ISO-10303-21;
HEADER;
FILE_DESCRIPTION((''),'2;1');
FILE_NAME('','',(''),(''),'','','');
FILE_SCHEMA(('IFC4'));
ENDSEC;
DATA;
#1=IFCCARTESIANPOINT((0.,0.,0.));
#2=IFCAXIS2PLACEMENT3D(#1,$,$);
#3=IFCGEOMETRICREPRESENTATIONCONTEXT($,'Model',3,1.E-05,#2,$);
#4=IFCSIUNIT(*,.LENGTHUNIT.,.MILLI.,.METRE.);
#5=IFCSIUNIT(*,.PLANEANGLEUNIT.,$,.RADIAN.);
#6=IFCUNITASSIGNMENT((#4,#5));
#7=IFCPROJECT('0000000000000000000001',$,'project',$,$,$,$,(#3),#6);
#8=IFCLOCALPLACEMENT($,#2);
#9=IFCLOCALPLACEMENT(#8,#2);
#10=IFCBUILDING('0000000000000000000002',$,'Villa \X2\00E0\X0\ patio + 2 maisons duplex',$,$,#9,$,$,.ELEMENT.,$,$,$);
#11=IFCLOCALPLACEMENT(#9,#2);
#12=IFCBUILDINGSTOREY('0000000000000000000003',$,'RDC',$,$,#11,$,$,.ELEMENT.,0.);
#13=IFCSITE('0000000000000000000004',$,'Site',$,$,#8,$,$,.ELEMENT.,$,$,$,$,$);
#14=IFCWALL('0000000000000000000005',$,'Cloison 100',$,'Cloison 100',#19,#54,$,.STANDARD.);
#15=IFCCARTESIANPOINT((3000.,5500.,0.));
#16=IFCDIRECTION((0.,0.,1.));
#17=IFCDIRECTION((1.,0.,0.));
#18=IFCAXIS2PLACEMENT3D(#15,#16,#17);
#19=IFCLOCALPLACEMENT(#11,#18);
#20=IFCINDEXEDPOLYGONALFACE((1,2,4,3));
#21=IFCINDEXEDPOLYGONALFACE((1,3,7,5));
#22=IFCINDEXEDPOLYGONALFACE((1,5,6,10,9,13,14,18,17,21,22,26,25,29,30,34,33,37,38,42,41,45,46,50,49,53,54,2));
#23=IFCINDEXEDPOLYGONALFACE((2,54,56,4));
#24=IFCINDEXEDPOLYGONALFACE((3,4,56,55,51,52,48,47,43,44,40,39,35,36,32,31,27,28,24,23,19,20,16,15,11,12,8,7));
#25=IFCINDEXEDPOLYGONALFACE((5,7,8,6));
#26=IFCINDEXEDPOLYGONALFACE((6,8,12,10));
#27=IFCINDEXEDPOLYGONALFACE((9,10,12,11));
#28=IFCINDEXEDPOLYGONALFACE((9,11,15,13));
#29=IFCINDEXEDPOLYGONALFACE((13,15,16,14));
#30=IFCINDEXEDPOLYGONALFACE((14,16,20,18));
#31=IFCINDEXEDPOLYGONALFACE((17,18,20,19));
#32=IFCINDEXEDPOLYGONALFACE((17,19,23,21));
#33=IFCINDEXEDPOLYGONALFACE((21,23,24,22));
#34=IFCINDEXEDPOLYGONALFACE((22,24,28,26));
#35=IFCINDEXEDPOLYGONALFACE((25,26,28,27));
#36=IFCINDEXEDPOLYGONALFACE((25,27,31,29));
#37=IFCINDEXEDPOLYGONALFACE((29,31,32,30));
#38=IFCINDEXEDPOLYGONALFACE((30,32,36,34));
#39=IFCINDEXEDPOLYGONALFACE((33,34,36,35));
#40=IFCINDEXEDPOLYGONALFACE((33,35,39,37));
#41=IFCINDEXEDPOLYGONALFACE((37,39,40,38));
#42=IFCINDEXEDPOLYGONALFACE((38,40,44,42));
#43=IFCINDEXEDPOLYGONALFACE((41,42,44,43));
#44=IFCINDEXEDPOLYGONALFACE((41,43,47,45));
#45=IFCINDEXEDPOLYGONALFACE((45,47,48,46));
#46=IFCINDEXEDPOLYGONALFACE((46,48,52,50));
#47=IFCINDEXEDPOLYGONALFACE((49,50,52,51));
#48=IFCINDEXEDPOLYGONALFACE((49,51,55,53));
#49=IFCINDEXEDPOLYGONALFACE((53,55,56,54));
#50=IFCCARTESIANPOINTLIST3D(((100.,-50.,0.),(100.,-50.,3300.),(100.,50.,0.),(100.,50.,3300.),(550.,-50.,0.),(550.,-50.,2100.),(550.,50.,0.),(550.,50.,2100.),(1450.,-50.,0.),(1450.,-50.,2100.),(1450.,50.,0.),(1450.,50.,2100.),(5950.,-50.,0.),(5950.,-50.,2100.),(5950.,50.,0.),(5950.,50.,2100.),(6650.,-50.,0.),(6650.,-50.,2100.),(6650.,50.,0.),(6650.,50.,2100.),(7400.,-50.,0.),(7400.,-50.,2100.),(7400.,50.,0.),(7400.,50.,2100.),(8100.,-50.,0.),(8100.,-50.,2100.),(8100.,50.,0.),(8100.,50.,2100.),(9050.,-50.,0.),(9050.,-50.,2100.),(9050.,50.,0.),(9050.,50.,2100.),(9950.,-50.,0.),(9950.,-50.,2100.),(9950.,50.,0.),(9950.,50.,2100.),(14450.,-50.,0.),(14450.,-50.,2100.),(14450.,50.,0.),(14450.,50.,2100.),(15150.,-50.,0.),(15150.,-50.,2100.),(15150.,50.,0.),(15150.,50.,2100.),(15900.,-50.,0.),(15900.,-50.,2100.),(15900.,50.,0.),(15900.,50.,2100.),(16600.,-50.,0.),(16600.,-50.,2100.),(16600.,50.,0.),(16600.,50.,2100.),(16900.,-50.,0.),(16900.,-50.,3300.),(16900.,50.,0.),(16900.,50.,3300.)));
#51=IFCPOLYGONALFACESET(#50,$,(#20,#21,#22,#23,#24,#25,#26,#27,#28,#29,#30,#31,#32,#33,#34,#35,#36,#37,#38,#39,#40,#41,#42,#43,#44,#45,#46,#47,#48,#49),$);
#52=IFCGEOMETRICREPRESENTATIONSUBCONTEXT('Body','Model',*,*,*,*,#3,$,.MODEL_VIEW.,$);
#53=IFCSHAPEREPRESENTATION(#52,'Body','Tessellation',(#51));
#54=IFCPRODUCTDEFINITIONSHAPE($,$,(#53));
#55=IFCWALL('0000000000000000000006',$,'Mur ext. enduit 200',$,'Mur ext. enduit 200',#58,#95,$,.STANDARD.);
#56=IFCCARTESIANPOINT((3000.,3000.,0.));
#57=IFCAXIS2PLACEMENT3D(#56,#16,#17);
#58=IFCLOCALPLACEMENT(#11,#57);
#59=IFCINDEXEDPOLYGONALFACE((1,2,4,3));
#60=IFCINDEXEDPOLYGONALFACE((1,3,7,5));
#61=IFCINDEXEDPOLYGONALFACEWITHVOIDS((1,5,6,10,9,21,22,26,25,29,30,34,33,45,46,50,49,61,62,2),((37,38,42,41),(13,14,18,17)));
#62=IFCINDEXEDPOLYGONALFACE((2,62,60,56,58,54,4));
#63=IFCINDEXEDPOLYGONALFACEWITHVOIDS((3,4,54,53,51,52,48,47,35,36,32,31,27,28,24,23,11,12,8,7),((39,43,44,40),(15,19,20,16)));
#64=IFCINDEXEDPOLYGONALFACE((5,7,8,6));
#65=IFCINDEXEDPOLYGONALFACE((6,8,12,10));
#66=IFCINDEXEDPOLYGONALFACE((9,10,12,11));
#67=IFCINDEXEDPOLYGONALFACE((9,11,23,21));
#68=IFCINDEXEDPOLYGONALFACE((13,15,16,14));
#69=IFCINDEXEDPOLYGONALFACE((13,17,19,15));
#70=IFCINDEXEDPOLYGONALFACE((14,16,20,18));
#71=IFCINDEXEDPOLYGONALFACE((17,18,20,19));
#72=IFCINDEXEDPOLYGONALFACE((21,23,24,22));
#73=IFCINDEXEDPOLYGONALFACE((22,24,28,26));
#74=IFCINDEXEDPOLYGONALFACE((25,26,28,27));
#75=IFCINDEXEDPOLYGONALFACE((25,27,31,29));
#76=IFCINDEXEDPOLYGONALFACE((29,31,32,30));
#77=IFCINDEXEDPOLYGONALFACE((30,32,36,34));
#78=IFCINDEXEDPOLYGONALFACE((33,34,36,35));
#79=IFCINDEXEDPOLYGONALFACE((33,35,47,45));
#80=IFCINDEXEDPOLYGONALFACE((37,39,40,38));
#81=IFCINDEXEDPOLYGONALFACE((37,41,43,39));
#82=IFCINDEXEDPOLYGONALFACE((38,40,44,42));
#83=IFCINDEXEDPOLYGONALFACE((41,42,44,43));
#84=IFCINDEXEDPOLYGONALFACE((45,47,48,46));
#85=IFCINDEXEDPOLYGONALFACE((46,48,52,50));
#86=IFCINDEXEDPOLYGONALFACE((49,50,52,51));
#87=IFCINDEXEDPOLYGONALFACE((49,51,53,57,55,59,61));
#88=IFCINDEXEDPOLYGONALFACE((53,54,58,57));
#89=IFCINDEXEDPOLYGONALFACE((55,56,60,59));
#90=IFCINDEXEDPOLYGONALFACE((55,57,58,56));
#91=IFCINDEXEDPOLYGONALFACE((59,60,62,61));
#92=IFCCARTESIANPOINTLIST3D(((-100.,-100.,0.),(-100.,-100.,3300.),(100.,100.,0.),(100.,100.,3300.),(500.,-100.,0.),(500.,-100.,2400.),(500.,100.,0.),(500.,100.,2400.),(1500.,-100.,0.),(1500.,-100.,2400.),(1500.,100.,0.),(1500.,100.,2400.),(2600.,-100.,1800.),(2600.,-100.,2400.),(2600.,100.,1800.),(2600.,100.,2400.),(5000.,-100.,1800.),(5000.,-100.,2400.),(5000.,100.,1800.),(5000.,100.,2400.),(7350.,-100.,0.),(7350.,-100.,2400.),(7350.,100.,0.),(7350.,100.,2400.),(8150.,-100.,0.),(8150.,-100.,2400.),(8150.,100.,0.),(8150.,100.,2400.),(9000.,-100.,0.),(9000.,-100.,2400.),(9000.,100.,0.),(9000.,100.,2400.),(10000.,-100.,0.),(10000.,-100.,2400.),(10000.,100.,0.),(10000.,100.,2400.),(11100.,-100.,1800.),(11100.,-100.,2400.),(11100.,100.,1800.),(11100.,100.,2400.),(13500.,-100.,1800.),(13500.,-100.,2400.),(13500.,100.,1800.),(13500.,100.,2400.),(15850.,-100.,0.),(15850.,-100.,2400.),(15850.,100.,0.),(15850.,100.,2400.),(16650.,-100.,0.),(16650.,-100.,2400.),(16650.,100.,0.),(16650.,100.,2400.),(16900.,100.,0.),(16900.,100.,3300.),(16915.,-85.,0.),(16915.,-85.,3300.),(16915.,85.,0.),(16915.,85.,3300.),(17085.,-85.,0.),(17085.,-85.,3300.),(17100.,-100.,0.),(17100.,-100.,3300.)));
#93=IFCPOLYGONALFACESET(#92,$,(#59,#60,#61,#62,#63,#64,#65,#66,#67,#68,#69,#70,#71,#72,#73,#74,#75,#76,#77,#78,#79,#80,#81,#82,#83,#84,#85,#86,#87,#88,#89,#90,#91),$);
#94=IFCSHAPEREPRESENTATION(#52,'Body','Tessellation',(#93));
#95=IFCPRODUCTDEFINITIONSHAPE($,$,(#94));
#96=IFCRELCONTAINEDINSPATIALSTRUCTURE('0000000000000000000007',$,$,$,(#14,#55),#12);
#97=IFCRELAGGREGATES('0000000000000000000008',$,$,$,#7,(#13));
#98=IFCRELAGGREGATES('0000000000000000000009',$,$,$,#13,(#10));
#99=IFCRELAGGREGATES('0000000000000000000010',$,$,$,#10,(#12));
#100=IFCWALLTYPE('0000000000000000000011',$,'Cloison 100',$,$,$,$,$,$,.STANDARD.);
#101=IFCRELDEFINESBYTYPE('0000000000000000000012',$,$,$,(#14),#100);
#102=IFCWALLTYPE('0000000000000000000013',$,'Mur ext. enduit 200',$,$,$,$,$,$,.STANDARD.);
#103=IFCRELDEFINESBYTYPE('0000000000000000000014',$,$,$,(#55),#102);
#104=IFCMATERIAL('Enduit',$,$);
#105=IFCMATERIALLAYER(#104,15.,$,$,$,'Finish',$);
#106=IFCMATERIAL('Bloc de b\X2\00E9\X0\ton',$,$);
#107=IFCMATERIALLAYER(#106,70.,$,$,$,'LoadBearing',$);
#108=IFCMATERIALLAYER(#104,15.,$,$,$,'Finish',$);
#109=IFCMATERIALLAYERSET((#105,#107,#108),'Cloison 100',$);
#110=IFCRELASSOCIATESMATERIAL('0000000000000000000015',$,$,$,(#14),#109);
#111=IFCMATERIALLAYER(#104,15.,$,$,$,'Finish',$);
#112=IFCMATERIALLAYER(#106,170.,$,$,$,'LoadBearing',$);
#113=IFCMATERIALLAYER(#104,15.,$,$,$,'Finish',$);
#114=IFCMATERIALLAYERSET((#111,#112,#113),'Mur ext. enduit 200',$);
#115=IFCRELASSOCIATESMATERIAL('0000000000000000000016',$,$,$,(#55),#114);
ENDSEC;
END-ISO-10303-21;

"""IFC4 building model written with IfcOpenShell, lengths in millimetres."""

from ifc_helpers import new_model, si_unit, frame, frame_2d, origin, place, context, subcontext, project, spatial, polyline, rectangle, outline, extrude, material, layer, layer_set, layer_usage, type_object, element, save


model = new_model("IFC4")

# Units and contexts
model_context = context("Model", 3, precision=1e-05, world=origin())
body_context = subcontext(model_context, "Body", "Model", "MODEL_VIEW")
ifc_project = project(units=[si_unit("LENGTHUNIT", "METRE", prefix="MILLI"), si_unit("PLANEANGLEUNIT", "RADIAN")], contexts=[model_context])

# Site, building, storey
site_placement = place(None, origin())
site = spatial("IfcSite", under=ifc_project, at=site_placement, Name="Site", CompositionType="ELEMENT")
building_placement = place(site_placement, origin())
building = spatial("IfcBuilding", under=site, at=building_placement, Name="Villa à patio + 2 maisons duplex", CompositionType="ELEMENT")
storey_placement = place(building_placement, origin())
storey = spatial("IfcBuildingStorey", under=building, at=storey_placement, Name="RDC", CompositionType="ELEMENT", Elevation=0.0)

# Shared definitions
ifc_material_1 = material(Name="Enduit")
ifc_layer_1 = layer(ifc_material_1, 15.0, Category="Finish")
ifc_material_2 = material(Name="Bloc de béton")
ifc_layer_2 = layer(ifc_material_2, 70.0, Category="LoadBearing")
ifc_layer_3 = layer(ifc_material_1, 15.0, Category="Finish")
ifc_layer_set_1 = layer_set([ifc_layer_1, ifc_layer_2, ifc_layer_3], Name="Cloison 100")
ifc_layer_usage_1 = layer_usage(ifc_layer_set_1, "AXIS2", "NEGATIVE", 50.0)
wall_type_1 = type_object("IfcWallType", Name="Cloison 100", PredefinedType="STANDARD")

# Wall, openings
wall_1_placement = place(storey_placement, frame((3000.0, 5500.0, 0.0), z_axis=(0.0, 0.0, 1.0), x_axis=(1.0, 0.0, 0.0)))
wall_1 = element("IfcWall", 1, at=wall_1_placement, inside=storey, type_object=wall_type_1, material=ifc_layer_usage_1, Name="Cloison 100", ObjectType="Cloison 100", PredefinedType="STANDARD", context=body_context, shape_type="SweptSolid", body=[
    extrude(outline(polyline([(100.0, -50.0), (100.0, 50.0), (16900.0, 50.0), (16900.0, -50.0), (100.0, -50.0)])), origin(), (0.0, 0.0, 1.0), 3300.0),
])
opening_1_placement = place(wall_1_placement, frame((550.0, 0.0, 0.0), z_axis=(0.0, 0.0, 1.0), x_axis=(1.0, 0.0, 0.0)))
element("IfcOpeningElement", 2, at=opening_1_placement, cuts=wall_1, PredefinedType="OPENING", context=body_context, shape_type="SweptSolid", body=[
    extrude(rectangle(XDim=900.0, YDim=120.0, at=frame_2d((450.0, 0.0))), origin(), (0.0, 0.0, 1.0), 2100.0),
])
opening_2_placement = place(wall_1_placement, frame((5950.0, 0.0, 0.0), z_axis=(0.0, 0.0, 1.0), x_axis=(1.0, 0.0, 0.0)))
element("IfcOpeningElement", 3, at=opening_2_placement, cuts=wall_1, PredefinedType="OPENING", context=body_context, shape_type="SweptSolid", body=[
    extrude(rectangle(XDim=700.0, YDim=120.0, at=frame_2d((350.0, 0.0))), origin(), (0.0, 0.0, 1.0), 2100.0),
])
opening_3_placement = place(wall_1_placement, frame((7400.0, 0.0, 0.0), z_axis=(0.0, 0.0, 1.0), x_axis=(1.0, 0.0, 0.0)))
element("IfcOpeningElement", 4, at=opening_3_placement, cuts=wall_1, PredefinedType="OPENING", context=body_context, shape_type="SweptSolid", body=[
    extrude(rectangle(XDim=700.0, YDim=120.0, at=frame_2d((350.0, 0.0))), origin(), (0.0, 0.0, 1.0), 2100.0),
])
opening_4_placement = place(wall_1_placement, frame((9050.0, 0.0, 0.0), z_axis=(0.0, 0.0, 1.0), x_axis=(1.0, 0.0, 0.0)))
element("IfcOpeningElement", 5, at=opening_4_placement, cuts=wall_1, PredefinedType="OPENING", context=body_context, shape_type="SweptSolid", body=[
    extrude(rectangle(XDim=900.0, YDim=120.0, at=frame_2d((450.0, 0.0))), origin(), (0.0, 0.0, 1.0), 2100.0),
])
opening_5_placement = place(wall_1_placement, frame((14450.0, 0.0, 0.0), z_axis=(0.0, 0.0, 1.0), x_axis=(1.0, 0.0, 0.0)))
element("IfcOpeningElement", 6, at=opening_5_placement, cuts=wall_1, PredefinedType="OPENING", context=body_context, shape_type="SweptSolid", body=[
    extrude(rectangle(XDim=700.0, YDim=120.0, at=frame_2d((350.0, 0.0))), origin(), (0.0, 0.0, 1.0), 2100.0),
])
opening_6_placement = place(wall_1_placement, frame((15900.0, 0.0, 0.0), z_axis=(0.0, 0.0, 1.0), x_axis=(1.0, 0.0, 0.0)))
element("IfcOpeningElement", 7, at=opening_6_placement, cuts=wall_1, PredefinedType="OPENING", context=body_context, shape_type="SweptSolid", body=[
    extrude(rectangle(XDim=700.0, YDim=120.0, at=frame_2d((350.0, 0.0))), origin(), (0.0, 0.0, 1.0), 2100.0),
])

# Wall, openings
ifc_layer_4 = layer(ifc_material_1, 15.0, Category="Finish")
ifc_layer_5 = layer(ifc_material_2, 170.0, Category="LoadBearing")
ifc_layer_6 = layer(ifc_material_1, 15.0, Category="Finish")
ifc_layer_set_2 = layer_set([ifc_layer_4, ifc_layer_5, ifc_layer_6], Name="Mur ext. enduit 200")
ifc_layer_usage_2 = layer_usage(ifc_layer_set_2, "AXIS2", "NEGATIVE", 100.0)
wall_type_2 = type_object("IfcWallType", Name="Mur ext. enduit 200", PredefinedType="STANDARD")
wall_2_placement = place(storey_placement, frame((3000.0, 3000.0, 0.0), z_axis=(0.0, 0.0, 1.0), x_axis=(1.0, 0.0, 0.0)))
wall_2 = element("IfcWall", 8, at=wall_2_placement, inside=storey, type_object=wall_type_2, material=ifc_layer_usage_2, Name="Mur ext. enduit 200", ObjectType="Mur ext. enduit 200", PredefinedType="STANDARD", context=body_context, shape_type="SweptSolid", body=[
    extrude(outline(polyline([(-100.0, -100.0), (0.0, 0.0), (100.0, 100.0), (16900.0, 100.0), (16915.0, 85.0), (16915.0, -85.0), (17085.0, -85.0), (17100.0, -100.0), (-100.0, -100.0)])), origin(), (0.0, 0.0, 1.0), 3300.0),
])
opening_7_placement = place(wall_2_placement, frame((500.0, 0.0, 0.0), z_axis=(0.0, 0.0, 1.0), x_axis=(1.0, 0.0, 0.0)))
element("IfcOpeningElement", 9, at=opening_7_placement, cuts=wall_2, PredefinedType="OPENING", context=body_context, shape_type="SweptSolid", body=[
    extrude(rectangle(XDim=1000.0, YDim=220.0, at=frame_2d((500.0, 0.0))), origin(), (0.0, 0.0, 1.0), 2400.0),
])
opening_8_placement = place(wall_2_placement, frame((7350.0, 0.0, 0.0), z_axis=(0.0, 0.0, 1.0), x_axis=(1.0, 0.0, 0.0)))
element("IfcOpeningElement", 10, at=opening_8_placement, cuts=wall_2, PredefinedType="OPENING", context=body_context, shape_type="SweptSolid", body=[
    extrude(rectangle(XDim=800.0, YDim=220.0, at=frame_2d((400.0, 0.0))), origin(), (0.0, 0.0, 1.0), 2400.0),
])
opening_9_placement = place(wall_2_placement, frame((2600.0, 0.0, 1800.0), z_axis=(0.0, 0.0, 1.0), x_axis=(1.0, 0.0, 0.0)))
element("IfcOpeningElement", 11, at=opening_9_placement, cuts=wall_2, PredefinedType="OPENING", context=body_context, shape_type="SweptSolid", body=[
    extrude(rectangle(XDim=2400.0, YDim=220.0, at=frame_2d((1200.0, 0.0))), origin(), (0.0, 0.0, 1.0), 600.0),
])
opening_10_placement = place(wall_2_placement, frame((9000.0, 0.0, 0.0), z_axis=(0.0, 0.0, 1.0), x_axis=(1.0, 0.0, 0.0)))
element("IfcOpeningElement", 12, at=opening_10_placement, cuts=wall_2, PredefinedType="OPENING", context=body_context, shape_type="SweptSolid", body=[
    extrude(rectangle(XDim=1000.0, YDim=220.0, at=frame_2d((500.0, 0.0))), origin(), (0.0, 0.0, 1.0), 2400.0),
])
opening_11_placement = place(wall_2_placement, frame((15850.0, 0.0, 0.0), z_axis=(0.0, 0.0, 1.0), x_axis=(1.0, 0.0, 0.0)))
element("IfcOpeningElement", 13, at=opening_11_placement, cuts=wall_2, PredefinedType="OPENING", context=body_context, shape_type="SweptSolid", body=[
    extrude(rectangle(XDim=800.0, YDim=220.0, at=frame_2d((400.0, 0.0))), origin(), (0.0, 0.0, 1.0), 2400.0),
])
opening_12_placement = place(wall_2_placement, frame((11100.0, 0.0, 1800.0), z_axis=(0.0, 0.0, 1.0), x_axis=(1.0, 0.0, 0.0)))
element("IfcOpeningElement", 14, at=opening_12_placement, cuts=wall_2, PredefinedType="OPENING", context=body_context, shape_type="SweptSolid", body=[
    extrude(rectangle(XDim=2400.0, YDim=220.0, at=frame_2d((1200.0, 0.0))), origin(), (0.0, 0.0, 1.0), 600.0),
])

save(model, "model.ifc")
